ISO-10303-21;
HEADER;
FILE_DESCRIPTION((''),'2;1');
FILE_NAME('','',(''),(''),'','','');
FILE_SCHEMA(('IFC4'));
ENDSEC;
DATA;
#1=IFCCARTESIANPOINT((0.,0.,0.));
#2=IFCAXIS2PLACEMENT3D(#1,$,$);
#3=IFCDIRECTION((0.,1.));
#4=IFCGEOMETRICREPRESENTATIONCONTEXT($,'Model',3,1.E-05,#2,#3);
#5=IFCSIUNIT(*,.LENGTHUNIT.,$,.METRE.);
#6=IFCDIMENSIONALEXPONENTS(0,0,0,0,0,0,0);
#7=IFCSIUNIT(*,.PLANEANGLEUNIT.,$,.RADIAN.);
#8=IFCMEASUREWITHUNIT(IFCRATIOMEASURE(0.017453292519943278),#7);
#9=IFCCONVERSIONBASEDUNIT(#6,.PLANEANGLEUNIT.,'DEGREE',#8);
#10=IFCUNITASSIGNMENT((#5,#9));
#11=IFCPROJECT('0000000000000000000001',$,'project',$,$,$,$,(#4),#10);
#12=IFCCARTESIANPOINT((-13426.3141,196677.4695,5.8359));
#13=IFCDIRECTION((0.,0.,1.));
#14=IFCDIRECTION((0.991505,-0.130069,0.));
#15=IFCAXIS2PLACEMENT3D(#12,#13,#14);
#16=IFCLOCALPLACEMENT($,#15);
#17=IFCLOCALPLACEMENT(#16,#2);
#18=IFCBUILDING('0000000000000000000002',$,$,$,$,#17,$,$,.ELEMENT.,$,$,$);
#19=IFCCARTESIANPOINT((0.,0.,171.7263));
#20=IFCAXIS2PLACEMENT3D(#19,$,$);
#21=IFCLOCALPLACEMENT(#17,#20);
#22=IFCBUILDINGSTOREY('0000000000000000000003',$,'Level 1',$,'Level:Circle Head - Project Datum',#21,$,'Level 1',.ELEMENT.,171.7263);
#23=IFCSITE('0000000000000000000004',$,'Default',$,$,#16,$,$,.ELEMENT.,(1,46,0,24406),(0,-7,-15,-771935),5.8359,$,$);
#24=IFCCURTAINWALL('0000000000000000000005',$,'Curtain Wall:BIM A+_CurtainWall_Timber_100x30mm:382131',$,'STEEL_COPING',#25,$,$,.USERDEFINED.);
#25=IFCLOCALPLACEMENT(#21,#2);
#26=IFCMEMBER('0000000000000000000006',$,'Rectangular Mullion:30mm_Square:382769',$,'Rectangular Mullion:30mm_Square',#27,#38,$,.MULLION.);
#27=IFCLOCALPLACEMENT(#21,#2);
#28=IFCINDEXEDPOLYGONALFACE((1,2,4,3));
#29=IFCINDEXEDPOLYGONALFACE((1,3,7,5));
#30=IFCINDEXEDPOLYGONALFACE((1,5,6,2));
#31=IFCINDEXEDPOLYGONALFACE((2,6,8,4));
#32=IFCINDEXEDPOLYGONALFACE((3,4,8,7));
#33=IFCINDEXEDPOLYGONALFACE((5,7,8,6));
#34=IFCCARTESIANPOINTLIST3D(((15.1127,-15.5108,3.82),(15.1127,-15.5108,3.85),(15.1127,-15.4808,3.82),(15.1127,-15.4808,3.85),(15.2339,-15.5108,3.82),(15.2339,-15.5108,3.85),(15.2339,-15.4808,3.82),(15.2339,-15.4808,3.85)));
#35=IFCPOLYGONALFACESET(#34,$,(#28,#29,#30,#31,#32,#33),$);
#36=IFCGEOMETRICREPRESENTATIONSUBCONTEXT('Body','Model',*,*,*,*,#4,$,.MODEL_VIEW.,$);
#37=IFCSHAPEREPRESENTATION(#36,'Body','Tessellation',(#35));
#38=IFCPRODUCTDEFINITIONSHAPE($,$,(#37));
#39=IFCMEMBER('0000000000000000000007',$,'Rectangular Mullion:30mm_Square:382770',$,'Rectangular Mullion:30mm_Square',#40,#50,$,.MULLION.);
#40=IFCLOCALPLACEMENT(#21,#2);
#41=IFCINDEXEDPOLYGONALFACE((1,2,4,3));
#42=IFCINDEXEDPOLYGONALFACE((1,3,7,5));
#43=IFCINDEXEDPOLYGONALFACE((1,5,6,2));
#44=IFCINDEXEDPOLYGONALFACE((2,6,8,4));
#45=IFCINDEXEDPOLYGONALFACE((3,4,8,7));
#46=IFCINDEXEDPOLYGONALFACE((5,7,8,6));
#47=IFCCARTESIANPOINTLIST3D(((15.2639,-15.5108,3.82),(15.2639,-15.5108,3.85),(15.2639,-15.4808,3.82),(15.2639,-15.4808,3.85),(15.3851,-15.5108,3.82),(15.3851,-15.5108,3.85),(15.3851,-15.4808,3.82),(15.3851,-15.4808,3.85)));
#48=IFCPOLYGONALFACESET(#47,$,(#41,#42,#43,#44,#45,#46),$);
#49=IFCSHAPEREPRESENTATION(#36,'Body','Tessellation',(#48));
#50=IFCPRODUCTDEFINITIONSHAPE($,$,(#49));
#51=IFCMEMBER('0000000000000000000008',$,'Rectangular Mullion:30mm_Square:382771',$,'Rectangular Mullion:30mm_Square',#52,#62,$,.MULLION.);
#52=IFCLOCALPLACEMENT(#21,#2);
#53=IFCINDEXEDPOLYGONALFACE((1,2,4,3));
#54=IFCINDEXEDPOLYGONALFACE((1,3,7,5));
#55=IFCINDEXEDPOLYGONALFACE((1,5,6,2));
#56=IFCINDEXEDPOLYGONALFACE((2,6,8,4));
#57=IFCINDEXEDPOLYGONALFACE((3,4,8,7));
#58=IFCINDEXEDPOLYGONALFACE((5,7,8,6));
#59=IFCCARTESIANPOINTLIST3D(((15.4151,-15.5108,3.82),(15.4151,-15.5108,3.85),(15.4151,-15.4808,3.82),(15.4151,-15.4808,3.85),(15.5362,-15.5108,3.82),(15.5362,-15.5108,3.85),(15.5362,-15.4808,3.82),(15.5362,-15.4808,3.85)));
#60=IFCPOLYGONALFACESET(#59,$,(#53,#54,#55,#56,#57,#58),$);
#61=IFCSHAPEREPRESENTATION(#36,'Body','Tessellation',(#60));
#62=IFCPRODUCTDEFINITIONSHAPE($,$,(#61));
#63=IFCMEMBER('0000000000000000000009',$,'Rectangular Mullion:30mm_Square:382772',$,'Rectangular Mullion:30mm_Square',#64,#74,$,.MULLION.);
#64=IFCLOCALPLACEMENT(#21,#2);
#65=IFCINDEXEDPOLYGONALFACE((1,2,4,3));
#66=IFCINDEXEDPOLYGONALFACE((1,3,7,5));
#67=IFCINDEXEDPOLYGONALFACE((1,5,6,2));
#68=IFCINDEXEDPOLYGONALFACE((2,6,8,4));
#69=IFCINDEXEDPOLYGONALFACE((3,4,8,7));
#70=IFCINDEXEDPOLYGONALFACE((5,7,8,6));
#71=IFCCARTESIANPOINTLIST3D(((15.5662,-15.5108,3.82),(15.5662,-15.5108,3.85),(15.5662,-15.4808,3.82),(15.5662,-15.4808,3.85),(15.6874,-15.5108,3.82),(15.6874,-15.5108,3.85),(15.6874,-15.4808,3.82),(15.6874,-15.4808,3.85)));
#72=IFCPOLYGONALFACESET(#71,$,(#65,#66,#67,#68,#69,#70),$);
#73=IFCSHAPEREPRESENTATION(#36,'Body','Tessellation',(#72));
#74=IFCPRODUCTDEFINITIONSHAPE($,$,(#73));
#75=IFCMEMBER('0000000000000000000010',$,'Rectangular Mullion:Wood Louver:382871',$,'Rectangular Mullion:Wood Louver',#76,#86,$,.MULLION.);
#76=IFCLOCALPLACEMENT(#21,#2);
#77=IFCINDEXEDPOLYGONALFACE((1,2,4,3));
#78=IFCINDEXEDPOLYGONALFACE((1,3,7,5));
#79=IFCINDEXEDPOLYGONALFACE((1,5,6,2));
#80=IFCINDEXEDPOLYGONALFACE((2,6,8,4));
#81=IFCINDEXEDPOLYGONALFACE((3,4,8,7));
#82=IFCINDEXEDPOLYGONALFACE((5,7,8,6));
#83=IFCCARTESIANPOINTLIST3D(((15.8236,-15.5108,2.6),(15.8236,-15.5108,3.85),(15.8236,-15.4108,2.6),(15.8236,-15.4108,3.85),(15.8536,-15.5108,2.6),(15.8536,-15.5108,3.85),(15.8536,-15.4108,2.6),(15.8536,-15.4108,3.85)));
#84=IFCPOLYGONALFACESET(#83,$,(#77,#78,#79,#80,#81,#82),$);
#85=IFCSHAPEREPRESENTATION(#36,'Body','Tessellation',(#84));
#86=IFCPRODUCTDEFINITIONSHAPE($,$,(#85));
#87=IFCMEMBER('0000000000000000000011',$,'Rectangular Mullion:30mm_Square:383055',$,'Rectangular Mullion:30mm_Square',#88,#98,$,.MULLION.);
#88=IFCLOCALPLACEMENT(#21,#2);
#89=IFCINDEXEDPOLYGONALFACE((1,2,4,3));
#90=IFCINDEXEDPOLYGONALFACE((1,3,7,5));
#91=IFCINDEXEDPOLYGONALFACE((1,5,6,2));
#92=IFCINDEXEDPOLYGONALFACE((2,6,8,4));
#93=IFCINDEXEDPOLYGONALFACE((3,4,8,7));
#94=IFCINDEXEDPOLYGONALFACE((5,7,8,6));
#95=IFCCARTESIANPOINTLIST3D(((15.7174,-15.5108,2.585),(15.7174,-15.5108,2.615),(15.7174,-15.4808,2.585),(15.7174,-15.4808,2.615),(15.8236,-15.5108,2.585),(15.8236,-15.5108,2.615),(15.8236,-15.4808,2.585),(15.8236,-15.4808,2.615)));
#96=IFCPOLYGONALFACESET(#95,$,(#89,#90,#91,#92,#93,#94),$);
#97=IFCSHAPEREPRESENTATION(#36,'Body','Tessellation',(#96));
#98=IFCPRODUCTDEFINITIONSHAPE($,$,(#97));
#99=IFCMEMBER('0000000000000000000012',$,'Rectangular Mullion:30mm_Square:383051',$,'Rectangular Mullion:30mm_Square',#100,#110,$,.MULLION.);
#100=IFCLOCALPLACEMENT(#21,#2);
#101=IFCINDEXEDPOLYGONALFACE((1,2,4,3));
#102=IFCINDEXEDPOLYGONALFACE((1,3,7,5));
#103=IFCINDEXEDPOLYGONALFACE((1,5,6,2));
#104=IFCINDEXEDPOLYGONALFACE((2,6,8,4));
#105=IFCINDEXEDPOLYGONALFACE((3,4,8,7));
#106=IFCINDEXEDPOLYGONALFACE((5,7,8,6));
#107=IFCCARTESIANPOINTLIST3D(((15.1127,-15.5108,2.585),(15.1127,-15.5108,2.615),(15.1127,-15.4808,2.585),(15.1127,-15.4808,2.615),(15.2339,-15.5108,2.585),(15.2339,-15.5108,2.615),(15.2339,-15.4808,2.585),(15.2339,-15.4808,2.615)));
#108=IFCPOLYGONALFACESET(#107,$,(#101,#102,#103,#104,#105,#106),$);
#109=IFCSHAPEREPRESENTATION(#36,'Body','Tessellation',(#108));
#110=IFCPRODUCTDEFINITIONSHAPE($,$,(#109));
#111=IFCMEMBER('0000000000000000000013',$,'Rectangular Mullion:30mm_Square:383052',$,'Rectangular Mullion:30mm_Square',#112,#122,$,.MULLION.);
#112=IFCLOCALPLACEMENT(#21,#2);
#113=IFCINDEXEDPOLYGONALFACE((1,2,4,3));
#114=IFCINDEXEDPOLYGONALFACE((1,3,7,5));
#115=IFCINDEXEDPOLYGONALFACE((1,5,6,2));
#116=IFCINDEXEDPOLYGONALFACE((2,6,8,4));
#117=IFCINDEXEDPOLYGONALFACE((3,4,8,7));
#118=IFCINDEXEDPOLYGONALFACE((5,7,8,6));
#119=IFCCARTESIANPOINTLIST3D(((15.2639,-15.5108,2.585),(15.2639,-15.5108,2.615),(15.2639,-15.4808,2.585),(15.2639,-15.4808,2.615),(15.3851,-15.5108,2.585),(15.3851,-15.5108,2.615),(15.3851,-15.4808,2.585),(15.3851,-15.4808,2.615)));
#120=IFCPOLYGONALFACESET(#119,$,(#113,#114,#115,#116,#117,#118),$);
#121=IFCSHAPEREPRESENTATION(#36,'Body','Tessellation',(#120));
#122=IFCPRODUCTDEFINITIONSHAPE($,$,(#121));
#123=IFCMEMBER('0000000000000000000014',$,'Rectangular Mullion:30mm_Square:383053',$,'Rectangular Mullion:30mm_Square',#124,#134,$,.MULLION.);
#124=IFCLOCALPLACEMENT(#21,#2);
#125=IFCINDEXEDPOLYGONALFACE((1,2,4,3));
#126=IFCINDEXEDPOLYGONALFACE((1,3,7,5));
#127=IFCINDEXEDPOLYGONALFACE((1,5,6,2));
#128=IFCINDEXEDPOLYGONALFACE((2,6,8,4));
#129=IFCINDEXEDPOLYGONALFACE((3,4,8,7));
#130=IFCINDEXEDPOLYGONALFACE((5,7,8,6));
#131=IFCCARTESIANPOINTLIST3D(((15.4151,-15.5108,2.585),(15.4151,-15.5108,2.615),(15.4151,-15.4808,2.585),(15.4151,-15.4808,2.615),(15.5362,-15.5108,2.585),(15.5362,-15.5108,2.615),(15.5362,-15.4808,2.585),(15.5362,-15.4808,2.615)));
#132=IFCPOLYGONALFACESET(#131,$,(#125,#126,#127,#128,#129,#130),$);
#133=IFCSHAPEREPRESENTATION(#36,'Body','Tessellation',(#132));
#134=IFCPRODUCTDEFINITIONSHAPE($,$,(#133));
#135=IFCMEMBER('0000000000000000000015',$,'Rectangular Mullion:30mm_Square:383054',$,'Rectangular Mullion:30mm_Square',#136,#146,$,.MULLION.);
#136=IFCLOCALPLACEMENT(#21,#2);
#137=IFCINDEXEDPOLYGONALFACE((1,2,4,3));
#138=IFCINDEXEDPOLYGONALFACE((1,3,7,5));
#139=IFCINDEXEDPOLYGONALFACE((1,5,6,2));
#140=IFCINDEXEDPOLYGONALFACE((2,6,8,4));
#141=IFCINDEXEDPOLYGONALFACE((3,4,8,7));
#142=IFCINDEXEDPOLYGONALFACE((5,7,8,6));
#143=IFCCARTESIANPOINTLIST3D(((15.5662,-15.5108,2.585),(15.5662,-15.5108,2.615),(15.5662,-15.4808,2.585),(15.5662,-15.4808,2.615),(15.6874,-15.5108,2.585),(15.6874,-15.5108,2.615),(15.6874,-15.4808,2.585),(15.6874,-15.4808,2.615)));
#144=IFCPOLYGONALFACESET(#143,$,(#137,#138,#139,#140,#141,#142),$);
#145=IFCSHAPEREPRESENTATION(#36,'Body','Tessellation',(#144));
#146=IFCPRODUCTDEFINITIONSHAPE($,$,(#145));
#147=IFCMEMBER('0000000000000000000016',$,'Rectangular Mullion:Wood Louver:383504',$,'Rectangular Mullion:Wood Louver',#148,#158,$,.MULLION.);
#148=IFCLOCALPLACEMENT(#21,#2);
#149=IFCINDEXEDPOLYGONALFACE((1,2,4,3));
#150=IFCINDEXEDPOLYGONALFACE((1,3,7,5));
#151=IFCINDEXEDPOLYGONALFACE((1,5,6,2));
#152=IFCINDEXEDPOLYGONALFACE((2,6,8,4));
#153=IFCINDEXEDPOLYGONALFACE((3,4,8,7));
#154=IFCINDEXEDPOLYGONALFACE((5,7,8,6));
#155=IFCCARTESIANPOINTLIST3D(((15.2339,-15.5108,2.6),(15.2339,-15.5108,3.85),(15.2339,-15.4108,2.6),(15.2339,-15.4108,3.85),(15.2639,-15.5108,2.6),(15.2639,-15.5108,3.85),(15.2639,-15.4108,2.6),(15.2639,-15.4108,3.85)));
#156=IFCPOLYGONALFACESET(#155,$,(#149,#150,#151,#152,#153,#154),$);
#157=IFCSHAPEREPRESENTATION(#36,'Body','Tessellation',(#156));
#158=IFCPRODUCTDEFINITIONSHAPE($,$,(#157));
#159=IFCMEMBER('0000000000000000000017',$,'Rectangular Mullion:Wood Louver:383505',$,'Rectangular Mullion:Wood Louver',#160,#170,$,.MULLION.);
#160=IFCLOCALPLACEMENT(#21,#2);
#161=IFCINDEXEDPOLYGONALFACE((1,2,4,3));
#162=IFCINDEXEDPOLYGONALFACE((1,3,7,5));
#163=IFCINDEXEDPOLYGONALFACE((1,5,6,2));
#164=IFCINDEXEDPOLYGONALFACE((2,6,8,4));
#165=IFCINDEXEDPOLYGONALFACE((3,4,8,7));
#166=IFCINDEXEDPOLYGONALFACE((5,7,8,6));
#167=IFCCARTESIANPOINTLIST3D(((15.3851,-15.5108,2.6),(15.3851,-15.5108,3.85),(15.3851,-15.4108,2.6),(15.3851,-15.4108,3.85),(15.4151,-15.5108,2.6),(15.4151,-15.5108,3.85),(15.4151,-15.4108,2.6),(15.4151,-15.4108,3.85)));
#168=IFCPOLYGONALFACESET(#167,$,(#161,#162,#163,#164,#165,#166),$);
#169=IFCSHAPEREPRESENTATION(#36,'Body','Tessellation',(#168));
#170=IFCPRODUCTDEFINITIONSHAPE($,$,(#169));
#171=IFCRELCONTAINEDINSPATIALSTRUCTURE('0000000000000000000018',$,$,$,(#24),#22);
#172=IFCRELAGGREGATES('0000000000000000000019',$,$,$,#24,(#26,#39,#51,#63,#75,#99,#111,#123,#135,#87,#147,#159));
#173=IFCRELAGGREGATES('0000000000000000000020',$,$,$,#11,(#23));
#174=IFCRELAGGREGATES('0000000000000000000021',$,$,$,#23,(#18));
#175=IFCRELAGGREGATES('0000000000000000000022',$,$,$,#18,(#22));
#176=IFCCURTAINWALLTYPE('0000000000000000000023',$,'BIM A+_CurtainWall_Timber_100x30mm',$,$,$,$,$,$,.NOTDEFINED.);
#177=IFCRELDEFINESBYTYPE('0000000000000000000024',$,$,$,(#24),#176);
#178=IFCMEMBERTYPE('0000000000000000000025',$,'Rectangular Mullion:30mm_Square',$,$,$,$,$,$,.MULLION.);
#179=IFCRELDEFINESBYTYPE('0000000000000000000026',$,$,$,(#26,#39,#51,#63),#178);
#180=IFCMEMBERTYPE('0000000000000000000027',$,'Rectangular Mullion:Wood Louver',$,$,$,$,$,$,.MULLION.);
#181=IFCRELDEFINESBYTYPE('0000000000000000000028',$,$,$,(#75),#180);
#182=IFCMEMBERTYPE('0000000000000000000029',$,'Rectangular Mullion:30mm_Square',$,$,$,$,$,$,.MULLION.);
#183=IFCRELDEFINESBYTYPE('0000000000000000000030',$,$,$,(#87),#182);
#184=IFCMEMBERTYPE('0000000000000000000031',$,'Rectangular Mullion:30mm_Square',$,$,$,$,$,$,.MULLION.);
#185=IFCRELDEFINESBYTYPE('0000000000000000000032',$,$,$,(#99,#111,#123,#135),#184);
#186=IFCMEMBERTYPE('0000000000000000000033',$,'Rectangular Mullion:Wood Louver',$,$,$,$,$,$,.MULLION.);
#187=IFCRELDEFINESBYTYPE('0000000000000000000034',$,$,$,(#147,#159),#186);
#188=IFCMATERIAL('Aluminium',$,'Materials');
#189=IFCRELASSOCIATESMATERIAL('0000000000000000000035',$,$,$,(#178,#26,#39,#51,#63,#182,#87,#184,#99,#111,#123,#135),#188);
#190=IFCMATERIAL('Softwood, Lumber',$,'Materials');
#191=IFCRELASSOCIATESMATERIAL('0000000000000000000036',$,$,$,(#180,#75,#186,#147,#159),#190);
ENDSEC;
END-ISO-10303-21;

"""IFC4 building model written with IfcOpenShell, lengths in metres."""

from ifc_helpers import new_model, entity, si_unit, converted_unit, direction, frame, origin, place, context, subcontext, project, spatial, indexed_curve, outline, extrude, source, transform, mapped, material, type_object, type_shapes, element, aggregate, save


model = new_model("IFC4")

# Units and contexts
model_context = context("Model", 3, precision=1e-05, world=origin(), true_north=direction((0.0, 1.0)))
body_context = subcontext(model_context, "Body", "Model", "MODEL_VIEW")
ifc_project = project(units=[si_unit("LENGTHUNIT", "METRE"), converted_unit("PLANEANGLEUNIT", "DEGREE", entity("IfcRatioMeasure", 0.017453292519943278), si_unit("PLANEANGLEUNIT", "RADIAN"), dimensions=[0, 0, 0, 0, 0, 0, 0])], contexts=[model_context])

# Site, building, storey
site_placement = place(None, frame((-13426.3141, 196677.4695, 5.8359), z_axis=(0.0, 0.0, 1.0), x_axis=(0.991505, -0.130069, 0.0)))
site = spatial("IfcSite", under=ifc_project, at=site_placement, Name="Default", CompositionType="ELEMENT", RefLatitude=(1, 46, 0, 24406), RefLongitude=(0, -7, -15, -771935), RefElevation=5.8359)
building_placement = place(site_placement, origin())
building = spatial("IfcBuilding", under=site, at=building_placement, CompositionType="ELEMENT")
storey_placement = place(building_placement, frame((0.0, 0.0, 171.7263)))
storey = spatial("IfcBuildingStorey", under=building, at=storey_placement, Name="Level 1", ObjectType="Level:Circle Head - Project Datum", LongName="Level 1", CompositionType="ELEMENT", Elevation=171.7263)

# Shared definitions
ifc_material_1 = material(Name="Aluminium", Category="Materials")

# Curtain wall, members
curtain_wall_type_1 = type_object("IfcCurtainWallType", Name="BIM A+_CurtainWall_Timber_100x30mm", PredefinedType="NOTDEFINED")
curtain_wall_1_placement = place(storey_placement, frame((0.0, 0.0, -171.7263)))
curtain_wall_1 = element("IfcCurtainWall", 1, at=curtain_wall_1_placement, inside=storey, type_object=curtain_wall_type_1, Name="Curtain Wall:BIM A+_CurtainWall_Timber_100x30mm:382131", ObjectType="STEEL_COPING", PredefinedType="USERDEFINED")
member_type_1 = type_object("IfcMemberType", Name="Rectangular Mullion:30mm_Square", PredefinedType="MULLION", material=ifc_material_1)
shared_shape_1 = source(origin(), body_context, "Body", "SweptSolid", [
    extrude(outline(indexed_curve([(-0.015, -0.015), (0.015, -0.015), (0.015, 0.015), (-0.015, 0.015), (-0.015, -0.015)], self_intersect=False)), frame((-0.015, 0.0, -0.1212), z_axis=(0.0, 0.0, 1.0), x_axis=(0.0, -1.0, 0.0)), (0.0, 0.0, 1.0), 0.1212),
])
type_shapes(member_type_1, [shared_shape_1])
member_1_placement = place(curtain_wall_1_placement, frame((15.2339, -15.4958, 175.5763), z_axis=(1.0, 0.0, 0.0), x_axis=(0.0, 0.0, 1.0)))
member_1 = element("IfcMember", 2, at=member_1_placement, type_object=member_type_1, material=ifc_material_1, Name="Rectangular Mullion:30mm_Square:382769", ObjectType="Rectangular Mullion:30mm_Square", PredefinedType="MULLION", context=body_context, shape_type="MappedRepresentation", body=[
    mapped(shared_shape_1, transform((0.0, 0.0, 0.0), scale=1.0)),
])
member_2_placement = place(curtain_wall_1_placement, frame((15.3851, -15.4958, 175.5763), z_axis=(1.0, 0.0, 0.0), x_axis=(0.0, 0.0, 1.0)))
member_2 = element("IfcMember", 3, at=member_2_placement, type_object=member_type_1, material=ifc_material_1, Name="Rectangular Mullion:30mm_Square:382770", ObjectType="Rectangular Mullion:30mm_Square", PredefinedType="MULLION", context=body_context, shape_type="MappedRepresentation", body=[
    mapped(shared_shape_1, transform((0.0, 0.0, 0.0), scale=1.0)),
])
member_3_placement = place(curtain_wall_1_placement, frame((15.5362, -15.4958, 175.5763), z_axis=(1.0, 0.0, 0.0), x_axis=(0.0, 0.0, 1.0)))
member_3 = element("IfcMember", 4, at=member_3_placement, type_object=member_type_1, material=ifc_material_1, Name="Rectangular Mullion:30mm_Square:382771", ObjectType="Rectangular Mullion:30mm_Square", PredefinedType="MULLION", context=body_context, shape_type="MappedRepresentation", body=[
    mapped(shared_shape_1, transform((0.0, 0.0, 0.0), scale=1.0)),
])
member_4_placement = place(curtain_wall_1_placement, frame((15.6874, -15.4958, 175.5763), z_axis=(1.0, 0.0, 0.0), x_axis=(0.0, 0.0, 1.0)))
member_4 = element("IfcMember", 5, at=member_4_placement, type_object=member_type_1, material=ifc_material_1, Name="Rectangular Mullion:30mm_Square:382772", ObjectType="Rectangular Mullion:30mm_Square", PredefinedType="MULLION", context=body_context, shape_type="MappedRepresentation", body=[
    mapped(shared_shape_1, transform((0.0, 0.0, 0.0), scale=1.0)),
])
ifc_material_2 = material(Name="Softwood, Lumber", Category="Materials")
member_type_2 = type_object("IfcMemberType", Name="Rectangular Mullion:Wood Louver", PredefinedType="MULLION", material=ifc_material_2)
shared_shape_2 = source(origin(), body_context, "Body", "SweptSolid", [
    extrude(outline(indexed_curve([(-0.05, -0.015), (0.05, -0.015), (0.05, 0.015), (-0.05, 0.015), (-0.05, -0.015)], self_intersect=False)), frame((-0.015, -0.035, -1.25), z_axis=(0.0, 0.0, 1.0), x_axis=(0.0, -1.0, 0.0)), (0.0, 0.0, 1.0), 1.25),
])
type_shapes(member_type_2, [shared_shape_2])
member_5_placement = place(curtain_wall_1_placement, frame((15.8536, -15.4958, 174.3263), z_axis=(0.0, 0.0, -1.0), x_axis=(1.0, 0.0, 0.0)))
member_5 = element("IfcMember", 6, at=member_5_placement, type_object=member_type_2, material=ifc_material_2, Name="Rectangular Mullion:Wood Louver:382871", ObjectType="Rectangular Mullion:Wood Louver", PredefinedType="MULLION", context=body_context, shape_type="MappedRepresentation", body=[
    mapped(shared_shape_2, transform((0.0, 0.0, 0.0), scale=1.0)),
])
member_type_3 = type_object("IfcMemberType", Name="Rectangular Mullion:30mm_Square", PredefinedType="MULLION", material=ifc_material_1)
shared_shape_3 = source(origin(), body_context, "Body", "SweptSolid", [
    extrude(outline(indexed_curve([(-0.015, -0.015), (0.015, -0.015), (0.015, 0.015), (-0.015, 0.015), (-0.015, -0.015)], self_intersect=False)), frame((0.0, 0.0, -0.1062), z_axis=(0.0, 0.0, 1.0), x_axis=(0.0, -1.0, 0.0)), (0.0, 0.0, 1.0), 0.1062),
])
type_shapes(member_type_3, [shared_shape_3])
member_6_placement = place(curtain_wall_1_placement, frame((15.8236, -15.4958, 174.3263), z_axis=(1.0, 0.0, 0.0), x_axis=(0.0, 0.0, 1.0)))
member_6 = element("IfcMember", 7, at=member_6_placement, type_object=member_type_3, material=ifc_material_1, Name="Rectangular Mullion:30mm_Square:383055", ObjectType="Rectangular Mullion:30mm_Square", PredefinedType="MULLION", context=body_context, shape_type="MappedRepresentation", body=[
    mapped(shared_shape_3, transform((0.0, 0.0, 0.0), scale=1.0)),
])
member_type_4 = type_object("IfcMemberType", Name="Rectangular Mullion:30mm_Square", PredefinedType="MULLION", material=ifc_material_1)
shared_shape_4 = source(origin(), body_context, "Body", "SweptSolid", [
    extrude(outline(indexed_curve([(-0.015, -0.015), (0.015, -0.015), (0.015, 0.015), (-0.015, 0.015), (-0.015, -0.015)], self_intersect=False)), frame((0.0, 0.0, -0.1212), z_axis=(0.0, 0.0, 1.0), x_axis=(0.0, -1.0, 0.0)), (0.0, 0.0, 1.0), 0.1212),
])
type_shapes(member_type_4, [shared_shape_4])
member_7_placement = place(curtain_wall_1_placement, frame((15.2339, -15.4958, 174.3263), z_axis=(1.0, 0.0, 0.0), x_axis=(0.0, 0.0, 1.0)))
member_7 = element("IfcMember", 8, at=member_7_placement, type_object=member_type_4, material=ifc_material_1, Name="Rectangular Mullion:30mm_Square:383051", ObjectType="Rectangular Mullion:30mm_Square", PredefinedType="MULLION", context=body_context, shape_type="MappedRepresentation", body=[
    mapped(shared_shape_4, transform((0.0, 0.0, 0.0), scale=1.0)),
])
member_8_placement = place(curtain_wall_1_placement, frame((15.3851, -15.4958, 174.3263), z_axis=(1.0, 0.0, 0.0), x_axis=(0.0, 0.0, 1.0)))
member_8 = element("IfcMember", 9, at=member_8_placement, type_object=member_type_4, material=ifc_material_1, Name="Rectangular Mullion:30mm_Square:383052", ObjectType="Rectangular Mullion:30mm_Square", PredefinedType="MULLION", context=body_context, shape_type="MappedRepresentation", body=[
    mapped(shared_shape_4, transform((0.0, 0.0, 0.0), scale=1.0)),
])
member_9_placement = place(curtain_wall_1_placement, frame((15.5362, -15.4958, 174.3263), z_axis=(1.0, 0.0, 0.0), x_axis=(0.0, 0.0, 1.0)))
member_9 = element("IfcMember", 10, at=member_9_placement, type_object=member_type_4, material=ifc_material_1, Name="Rectangular Mullion:30mm_Square:383053", ObjectType="Rectangular Mullion:30mm_Square", PredefinedType="MULLION", context=body_context, shape_type="MappedRepresentation", body=[
    mapped(shared_shape_4, transform((0.0, 0.0, 0.0), scale=1.0)),
])
member_10_placement = place(curtain_wall_1_placement, frame((15.6874, -15.4958, 174.3263), z_axis=(1.0, 0.0, 0.0), x_axis=(0.0, 0.0, 1.0)))
member_10 = element("IfcMember", 11, at=member_10_placement, type_object=member_type_4, material=ifc_material_1, Name="Rectangular Mullion:30mm_Square:383054", ObjectType="Rectangular Mullion:30mm_Square", PredefinedType="MULLION", context=body_context, shape_type="MappedRepresentation", body=[
    mapped(shared_shape_4, transform((0.0, 0.0, 0.0), scale=1.0)),
])
member_type_5 = type_object("IfcMemberType", Name="Rectangular Mullion:Wood Louver", PredefinedType="MULLION", material=ifc_material_2)
shared_shape_5 = source(origin(), body_context, "Body", "SweptSolid", [
    extrude(outline(indexed_curve([(-0.05, -0.015), (0.05, -0.015), (0.05, 0.015), (-0.05, 0.015), (-0.05, -0.015)], self_intersect=False)), frame((0.0, -0.035, -1.25), z_axis=(0.0, 0.0, 1.0), x_axis=(0.0, -1.0, 0.0)), (0.0, 0.0, 1.0), 1.25),
])
type_shapes(member_type_5, [shared_shape_5])
member_11_placement = place(curtain_wall_1_placement, frame((15.2489, -15.4958, 174.3263), z_axis=(0.0, 0.0, -1.0), x_axis=(1.0, 0.0, 0.0)))
member_11 = element("IfcMember", 12, at=member_11_placement, type_object=member_type_5, material=ifc_material_2, Name="Rectangular Mullion:Wood Louver:383504", ObjectType="Rectangular Mullion:Wood Louver", PredefinedType="MULLION", context=body_context, shape_type="MappedRepresentation", body=[
    mapped(shared_shape_5, transform((0.0, 0.0, 0.0), scale=1.0)),
])
member_12_placement = place(curtain_wall_1_placement, frame((15.4001, -15.4958, 174.3263), z_axis=(0.0, 0.0, -1.0), x_axis=(1.0, 0.0, 0.0)))
member_12 = element("IfcMember", 13, at=member_12_placement, type_object=member_type_5, material=ifc_material_2, Name="Rectangular Mullion:Wood Louver:383505", ObjectType="Rectangular Mullion:Wood Louver", PredefinedType="MULLION", context=body_context, shape_type="MappedRepresentation", body=[
    mapped(shared_shape_5, transform((0.0, 0.0, 0.0), scale=1.0)),
])

aggregate(curtain_wall_1, [member_1, member_2, member_3, member_4, member_5, member_7, member_8, member_9, member_10, member_6, member_11, member_12])

save(model, "model.ifc")
